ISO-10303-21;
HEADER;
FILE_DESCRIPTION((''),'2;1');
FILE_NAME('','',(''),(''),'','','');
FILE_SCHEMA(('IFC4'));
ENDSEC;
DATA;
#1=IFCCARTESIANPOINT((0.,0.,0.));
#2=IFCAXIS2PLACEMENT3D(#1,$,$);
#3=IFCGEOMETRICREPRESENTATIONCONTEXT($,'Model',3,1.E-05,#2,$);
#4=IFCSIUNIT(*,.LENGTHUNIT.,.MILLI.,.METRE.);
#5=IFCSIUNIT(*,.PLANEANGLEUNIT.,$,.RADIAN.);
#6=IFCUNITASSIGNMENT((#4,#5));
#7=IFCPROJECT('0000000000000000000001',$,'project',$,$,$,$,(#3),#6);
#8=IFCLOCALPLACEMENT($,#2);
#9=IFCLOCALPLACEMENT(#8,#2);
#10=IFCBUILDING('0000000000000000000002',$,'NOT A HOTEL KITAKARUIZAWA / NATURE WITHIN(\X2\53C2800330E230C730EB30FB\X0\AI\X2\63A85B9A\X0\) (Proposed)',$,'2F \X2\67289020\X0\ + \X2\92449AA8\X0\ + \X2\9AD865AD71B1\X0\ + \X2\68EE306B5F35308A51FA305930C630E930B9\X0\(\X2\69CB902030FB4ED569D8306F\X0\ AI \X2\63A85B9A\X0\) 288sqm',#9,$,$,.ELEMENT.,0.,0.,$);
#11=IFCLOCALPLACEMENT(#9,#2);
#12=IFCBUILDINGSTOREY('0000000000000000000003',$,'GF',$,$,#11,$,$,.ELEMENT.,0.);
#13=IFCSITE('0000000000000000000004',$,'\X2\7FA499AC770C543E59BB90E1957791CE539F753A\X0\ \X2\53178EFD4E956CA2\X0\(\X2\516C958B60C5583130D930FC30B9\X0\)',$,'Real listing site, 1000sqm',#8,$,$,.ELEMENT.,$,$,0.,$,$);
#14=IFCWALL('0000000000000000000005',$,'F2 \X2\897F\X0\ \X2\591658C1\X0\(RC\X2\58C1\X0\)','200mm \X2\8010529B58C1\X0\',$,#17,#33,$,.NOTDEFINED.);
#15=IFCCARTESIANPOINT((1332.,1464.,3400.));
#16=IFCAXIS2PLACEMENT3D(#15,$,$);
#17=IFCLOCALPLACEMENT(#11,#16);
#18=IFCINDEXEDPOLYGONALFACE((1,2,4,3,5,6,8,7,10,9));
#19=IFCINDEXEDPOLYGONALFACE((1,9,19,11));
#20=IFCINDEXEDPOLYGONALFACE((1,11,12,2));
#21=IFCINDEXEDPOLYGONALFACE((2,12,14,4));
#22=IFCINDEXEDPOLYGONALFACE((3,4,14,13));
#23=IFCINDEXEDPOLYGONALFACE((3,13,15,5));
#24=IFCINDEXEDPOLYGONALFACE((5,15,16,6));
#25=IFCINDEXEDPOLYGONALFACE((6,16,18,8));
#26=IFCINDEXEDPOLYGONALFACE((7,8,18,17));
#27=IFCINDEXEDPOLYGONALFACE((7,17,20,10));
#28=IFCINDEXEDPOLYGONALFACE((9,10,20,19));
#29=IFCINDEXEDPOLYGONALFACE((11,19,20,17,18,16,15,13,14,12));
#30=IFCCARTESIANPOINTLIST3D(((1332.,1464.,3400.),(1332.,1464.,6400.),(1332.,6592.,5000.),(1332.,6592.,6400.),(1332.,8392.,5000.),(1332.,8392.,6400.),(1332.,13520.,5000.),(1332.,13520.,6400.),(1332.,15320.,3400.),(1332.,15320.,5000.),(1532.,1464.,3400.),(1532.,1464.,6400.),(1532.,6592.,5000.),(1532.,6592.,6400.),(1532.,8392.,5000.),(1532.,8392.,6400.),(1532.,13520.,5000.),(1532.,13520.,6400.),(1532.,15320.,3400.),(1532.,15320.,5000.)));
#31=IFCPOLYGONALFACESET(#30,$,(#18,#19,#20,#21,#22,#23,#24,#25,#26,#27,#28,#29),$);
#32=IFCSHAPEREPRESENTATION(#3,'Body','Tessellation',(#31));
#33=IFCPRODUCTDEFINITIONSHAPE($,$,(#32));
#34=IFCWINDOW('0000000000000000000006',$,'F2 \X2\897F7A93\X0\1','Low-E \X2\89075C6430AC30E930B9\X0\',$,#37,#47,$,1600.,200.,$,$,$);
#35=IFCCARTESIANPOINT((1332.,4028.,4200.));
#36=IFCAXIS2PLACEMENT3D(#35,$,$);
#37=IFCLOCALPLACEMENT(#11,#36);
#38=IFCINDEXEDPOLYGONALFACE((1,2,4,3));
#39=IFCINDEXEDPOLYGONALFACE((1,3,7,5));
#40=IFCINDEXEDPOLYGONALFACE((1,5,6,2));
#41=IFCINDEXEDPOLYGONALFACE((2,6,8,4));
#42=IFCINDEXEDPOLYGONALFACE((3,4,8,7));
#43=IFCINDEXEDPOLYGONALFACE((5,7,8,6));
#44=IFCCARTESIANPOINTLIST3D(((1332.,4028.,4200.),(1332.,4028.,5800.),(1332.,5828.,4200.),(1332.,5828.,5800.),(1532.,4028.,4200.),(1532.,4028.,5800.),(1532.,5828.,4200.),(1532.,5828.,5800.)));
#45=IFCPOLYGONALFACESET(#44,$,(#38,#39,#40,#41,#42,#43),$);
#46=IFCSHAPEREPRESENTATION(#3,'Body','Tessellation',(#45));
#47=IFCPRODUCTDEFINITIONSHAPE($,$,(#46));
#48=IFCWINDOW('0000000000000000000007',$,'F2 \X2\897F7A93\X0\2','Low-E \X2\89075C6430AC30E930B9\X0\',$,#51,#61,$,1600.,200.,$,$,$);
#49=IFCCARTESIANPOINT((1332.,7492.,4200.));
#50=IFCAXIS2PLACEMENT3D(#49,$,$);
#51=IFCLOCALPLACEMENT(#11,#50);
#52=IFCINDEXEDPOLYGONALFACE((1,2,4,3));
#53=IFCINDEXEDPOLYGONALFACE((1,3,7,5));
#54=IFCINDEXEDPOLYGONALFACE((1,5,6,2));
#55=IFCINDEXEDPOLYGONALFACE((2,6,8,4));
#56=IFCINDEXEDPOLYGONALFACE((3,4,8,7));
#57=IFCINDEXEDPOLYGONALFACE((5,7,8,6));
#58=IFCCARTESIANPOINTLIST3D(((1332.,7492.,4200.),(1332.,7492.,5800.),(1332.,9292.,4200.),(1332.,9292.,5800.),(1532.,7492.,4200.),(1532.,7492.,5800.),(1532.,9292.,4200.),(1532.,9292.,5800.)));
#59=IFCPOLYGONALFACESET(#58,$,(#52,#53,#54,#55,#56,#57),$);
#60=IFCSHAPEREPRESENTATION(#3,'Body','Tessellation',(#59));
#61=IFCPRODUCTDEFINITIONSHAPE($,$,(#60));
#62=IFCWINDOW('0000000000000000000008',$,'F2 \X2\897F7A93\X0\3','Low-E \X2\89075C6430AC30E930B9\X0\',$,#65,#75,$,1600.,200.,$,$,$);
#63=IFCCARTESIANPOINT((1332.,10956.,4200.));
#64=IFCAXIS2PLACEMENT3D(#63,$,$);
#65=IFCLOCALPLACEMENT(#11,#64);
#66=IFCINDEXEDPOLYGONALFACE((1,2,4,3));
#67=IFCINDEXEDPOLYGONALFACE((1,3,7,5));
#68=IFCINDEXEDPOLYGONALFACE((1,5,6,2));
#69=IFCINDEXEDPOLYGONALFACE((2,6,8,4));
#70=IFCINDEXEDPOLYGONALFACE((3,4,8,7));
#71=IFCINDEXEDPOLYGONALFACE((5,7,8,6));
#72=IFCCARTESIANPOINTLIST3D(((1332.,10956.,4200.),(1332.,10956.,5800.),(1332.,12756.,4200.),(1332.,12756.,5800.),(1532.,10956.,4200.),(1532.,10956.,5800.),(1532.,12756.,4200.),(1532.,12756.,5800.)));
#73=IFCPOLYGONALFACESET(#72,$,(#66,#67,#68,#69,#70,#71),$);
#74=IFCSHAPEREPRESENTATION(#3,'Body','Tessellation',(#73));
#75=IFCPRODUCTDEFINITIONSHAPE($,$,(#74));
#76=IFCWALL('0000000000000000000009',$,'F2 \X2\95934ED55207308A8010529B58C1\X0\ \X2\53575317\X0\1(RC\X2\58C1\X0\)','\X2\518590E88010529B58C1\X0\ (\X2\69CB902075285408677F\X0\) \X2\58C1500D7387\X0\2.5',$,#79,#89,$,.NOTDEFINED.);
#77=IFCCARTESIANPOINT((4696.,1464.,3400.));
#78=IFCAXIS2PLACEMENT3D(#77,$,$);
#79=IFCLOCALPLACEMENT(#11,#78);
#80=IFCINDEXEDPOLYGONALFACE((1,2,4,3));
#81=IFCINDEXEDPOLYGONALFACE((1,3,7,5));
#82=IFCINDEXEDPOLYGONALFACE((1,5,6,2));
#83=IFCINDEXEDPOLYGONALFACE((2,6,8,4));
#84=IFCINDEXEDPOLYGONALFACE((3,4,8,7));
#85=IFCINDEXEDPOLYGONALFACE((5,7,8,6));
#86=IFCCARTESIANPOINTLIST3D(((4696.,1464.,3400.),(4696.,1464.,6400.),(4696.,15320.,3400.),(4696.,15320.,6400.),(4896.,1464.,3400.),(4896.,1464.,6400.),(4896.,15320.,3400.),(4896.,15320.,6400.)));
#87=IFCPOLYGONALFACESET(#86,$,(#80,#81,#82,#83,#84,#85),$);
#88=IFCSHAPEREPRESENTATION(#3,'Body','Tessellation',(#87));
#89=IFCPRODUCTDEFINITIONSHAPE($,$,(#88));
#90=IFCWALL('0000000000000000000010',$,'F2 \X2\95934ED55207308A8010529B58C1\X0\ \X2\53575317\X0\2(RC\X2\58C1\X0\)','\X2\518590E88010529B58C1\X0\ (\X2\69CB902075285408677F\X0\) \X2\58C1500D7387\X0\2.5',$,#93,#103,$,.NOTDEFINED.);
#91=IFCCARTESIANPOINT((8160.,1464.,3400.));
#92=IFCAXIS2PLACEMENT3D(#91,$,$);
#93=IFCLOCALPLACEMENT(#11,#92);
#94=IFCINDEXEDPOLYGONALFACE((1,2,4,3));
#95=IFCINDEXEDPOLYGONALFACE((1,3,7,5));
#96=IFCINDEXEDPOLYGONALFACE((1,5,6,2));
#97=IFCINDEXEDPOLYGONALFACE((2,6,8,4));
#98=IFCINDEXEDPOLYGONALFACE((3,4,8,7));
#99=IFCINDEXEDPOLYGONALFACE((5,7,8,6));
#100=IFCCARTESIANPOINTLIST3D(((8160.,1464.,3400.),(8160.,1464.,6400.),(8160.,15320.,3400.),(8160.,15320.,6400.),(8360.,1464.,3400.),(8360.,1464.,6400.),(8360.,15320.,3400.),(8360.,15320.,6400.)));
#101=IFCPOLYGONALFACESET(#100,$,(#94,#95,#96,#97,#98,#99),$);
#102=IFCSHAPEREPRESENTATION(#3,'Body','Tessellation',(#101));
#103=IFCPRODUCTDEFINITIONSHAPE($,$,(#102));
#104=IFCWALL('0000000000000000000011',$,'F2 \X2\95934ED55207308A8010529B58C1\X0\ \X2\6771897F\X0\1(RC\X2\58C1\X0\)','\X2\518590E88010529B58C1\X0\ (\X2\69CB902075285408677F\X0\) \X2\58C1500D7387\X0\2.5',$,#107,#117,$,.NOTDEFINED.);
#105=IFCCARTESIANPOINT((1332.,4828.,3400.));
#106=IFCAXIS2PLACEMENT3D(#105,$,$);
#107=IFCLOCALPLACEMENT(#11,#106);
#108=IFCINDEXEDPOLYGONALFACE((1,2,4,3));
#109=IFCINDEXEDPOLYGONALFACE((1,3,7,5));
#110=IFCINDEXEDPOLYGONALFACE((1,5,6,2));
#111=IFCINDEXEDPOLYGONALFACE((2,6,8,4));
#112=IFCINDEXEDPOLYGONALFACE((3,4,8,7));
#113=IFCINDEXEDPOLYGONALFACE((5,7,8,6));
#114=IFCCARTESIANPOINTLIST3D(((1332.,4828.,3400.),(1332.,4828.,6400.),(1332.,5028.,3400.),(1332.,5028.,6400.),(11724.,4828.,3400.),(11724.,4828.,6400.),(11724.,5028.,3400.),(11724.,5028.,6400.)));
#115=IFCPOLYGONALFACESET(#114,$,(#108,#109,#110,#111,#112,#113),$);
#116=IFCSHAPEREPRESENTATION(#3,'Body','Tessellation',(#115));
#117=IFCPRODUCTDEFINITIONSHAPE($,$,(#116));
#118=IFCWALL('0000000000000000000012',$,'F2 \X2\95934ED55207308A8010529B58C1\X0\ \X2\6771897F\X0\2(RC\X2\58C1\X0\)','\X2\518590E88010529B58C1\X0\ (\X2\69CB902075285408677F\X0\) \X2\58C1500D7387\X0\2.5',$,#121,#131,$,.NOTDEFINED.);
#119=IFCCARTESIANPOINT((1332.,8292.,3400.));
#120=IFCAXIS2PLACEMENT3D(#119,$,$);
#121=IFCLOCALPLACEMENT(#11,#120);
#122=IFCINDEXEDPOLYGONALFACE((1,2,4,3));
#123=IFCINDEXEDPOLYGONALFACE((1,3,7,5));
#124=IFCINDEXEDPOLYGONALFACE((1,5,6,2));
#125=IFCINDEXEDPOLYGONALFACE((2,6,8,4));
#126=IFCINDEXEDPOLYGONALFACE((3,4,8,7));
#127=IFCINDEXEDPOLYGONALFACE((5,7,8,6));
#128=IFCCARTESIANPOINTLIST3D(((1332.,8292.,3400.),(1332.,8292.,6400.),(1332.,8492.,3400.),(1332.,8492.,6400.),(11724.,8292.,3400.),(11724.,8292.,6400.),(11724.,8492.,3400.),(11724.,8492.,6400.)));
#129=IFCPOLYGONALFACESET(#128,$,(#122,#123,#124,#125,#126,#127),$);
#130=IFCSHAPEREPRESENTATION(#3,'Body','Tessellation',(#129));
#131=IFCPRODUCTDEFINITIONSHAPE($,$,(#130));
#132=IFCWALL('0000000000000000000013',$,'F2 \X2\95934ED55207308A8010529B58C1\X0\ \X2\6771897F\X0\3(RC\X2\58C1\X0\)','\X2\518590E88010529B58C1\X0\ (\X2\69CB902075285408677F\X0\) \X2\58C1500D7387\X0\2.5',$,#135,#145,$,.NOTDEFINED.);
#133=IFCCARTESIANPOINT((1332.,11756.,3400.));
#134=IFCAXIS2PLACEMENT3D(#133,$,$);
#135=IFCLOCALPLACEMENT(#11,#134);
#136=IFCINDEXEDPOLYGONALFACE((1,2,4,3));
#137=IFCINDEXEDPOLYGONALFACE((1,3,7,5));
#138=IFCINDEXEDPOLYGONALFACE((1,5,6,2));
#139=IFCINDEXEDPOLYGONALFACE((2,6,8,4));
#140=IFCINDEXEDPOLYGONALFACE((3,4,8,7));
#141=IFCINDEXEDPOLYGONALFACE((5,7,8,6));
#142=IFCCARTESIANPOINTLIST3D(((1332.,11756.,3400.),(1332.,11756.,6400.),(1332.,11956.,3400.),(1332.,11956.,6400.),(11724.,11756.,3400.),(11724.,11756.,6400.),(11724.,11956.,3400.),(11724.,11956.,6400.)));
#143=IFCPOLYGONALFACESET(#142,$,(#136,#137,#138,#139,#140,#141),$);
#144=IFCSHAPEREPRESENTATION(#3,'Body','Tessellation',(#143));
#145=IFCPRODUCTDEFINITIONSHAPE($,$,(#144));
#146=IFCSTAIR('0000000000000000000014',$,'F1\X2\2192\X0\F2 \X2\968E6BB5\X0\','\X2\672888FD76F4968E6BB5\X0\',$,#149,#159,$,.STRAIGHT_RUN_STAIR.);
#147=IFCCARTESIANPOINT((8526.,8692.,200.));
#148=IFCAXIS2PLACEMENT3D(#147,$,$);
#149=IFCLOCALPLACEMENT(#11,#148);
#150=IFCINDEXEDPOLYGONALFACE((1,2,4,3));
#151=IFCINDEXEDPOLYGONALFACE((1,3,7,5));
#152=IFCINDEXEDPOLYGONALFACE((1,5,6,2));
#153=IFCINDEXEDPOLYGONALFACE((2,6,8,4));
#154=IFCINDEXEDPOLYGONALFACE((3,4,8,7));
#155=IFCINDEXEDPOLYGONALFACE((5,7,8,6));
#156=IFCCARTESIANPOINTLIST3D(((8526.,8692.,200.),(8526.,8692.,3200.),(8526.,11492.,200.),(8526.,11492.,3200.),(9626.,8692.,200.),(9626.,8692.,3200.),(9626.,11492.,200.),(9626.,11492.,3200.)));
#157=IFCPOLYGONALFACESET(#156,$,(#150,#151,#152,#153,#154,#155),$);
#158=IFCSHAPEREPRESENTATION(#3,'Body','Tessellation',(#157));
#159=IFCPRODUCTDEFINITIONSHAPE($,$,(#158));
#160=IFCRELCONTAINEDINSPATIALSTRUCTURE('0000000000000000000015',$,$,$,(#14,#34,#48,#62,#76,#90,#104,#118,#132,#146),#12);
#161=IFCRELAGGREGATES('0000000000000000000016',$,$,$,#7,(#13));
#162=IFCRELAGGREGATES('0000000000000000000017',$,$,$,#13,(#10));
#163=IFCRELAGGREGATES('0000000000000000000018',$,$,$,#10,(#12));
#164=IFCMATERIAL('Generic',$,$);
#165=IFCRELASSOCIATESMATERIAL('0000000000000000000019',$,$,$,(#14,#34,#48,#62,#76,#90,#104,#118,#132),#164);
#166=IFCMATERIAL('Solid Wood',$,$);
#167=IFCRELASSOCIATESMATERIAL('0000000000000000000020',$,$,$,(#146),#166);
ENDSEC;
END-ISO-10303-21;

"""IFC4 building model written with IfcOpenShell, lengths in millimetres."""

from ifc_helpers import new_model, si_unit, frame, frame_2d, origin, place, context, project, spatial, rectangle, extrude, material, element, fill, save


model = new_model("IFC4")

# Units and contexts
model_context = context("Model", 3, precision=1e-05, world=origin())
ifc_project = project(units=[si_unit("LENGTHUNIT", "METRE", prefix="MILLI"), si_unit("PLANEANGLEUNIT", "RADIAN")], contexts=[model_context])

# Site, building, storey
site_placement = place(None, origin())
site = spatial("IfcSite", under=ifc_project, at=site_placement, Name="群馬県吾妻郡長野原町 北軽井沢(公開情報ベース)", ObjectType="Real listing site, 1000sqm", CompositionType="ELEMENT", RefElevation=0.0)
building_placement = place(site_placement, origin())
building = spatial("IfcBuilding", under=site, at=building_placement, Name="NOT A HOTEL KITAKARUIZAWA / NATURE WITHIN(参考モデル・AI推定) (Proposed)", ObjectType="2F 木造 + 鉄骨 + 高断熱 + 森に張り出すテラス(構造・仕様は AI 推定) 288sqm", CompositionType="ELEMENT", ElevationOfRefHeight=0.0, ElevationOfTerrain=0.0)
storey_placement = place(building_placement, origin())
storey = spatial("IfcBuildingStorey", under=building, at=storey_placement, Name="GF", CompositionType="ELEMENT", Elevation=0.0)

# Shared definitions
ifc_material_1 = material(Name="Generic")

# Wall, openings, windows
wall_1_placement = place(storey_placement, frame((1332.0, 1464.0, 3400.0)))
wall_1 = element("IfcWall", 1, at=wall_1_placement, inside=storey, material=ifc_material_1, Name="F2 西 外壁(RC壁)", Description="200mm 耐力壁", PredefinedType="NOTDEFINED", context=model_context, shape_type="SweptSolid", body=[
    extrude(rectangle(XDim=200.0, YDim=13856.0, at=frame_2d((100.0, 6928.0))), frame((1332.0, 1464.0, 3400.0)), (0.0, 0.0, 1.0), 3000.0),
])
opening_1_placement = place(storey_placement, frame((1332.0, 4028.0, 4200.0)))
opening_1 = element("IfcOpeningElement", 2, at=opening_1_placement, cuts=wall_1, PredefinedType="NOTDEFINED", context=model_context, shape_type="SweptSolid", body=[
    extrude(rectangle(XDim=200.0, YDim=1800.0, at=frame_2d((100.0, 900.0))), frame((1332.0, 4028.0, 4200.0)), (0.0, 0.0, 1.0), 1600.0),
])
opening_2_placement = place(storey_placement, frame((1332.0, 7492.0, 4200.0)))
opening_2 = element("IfcOpeningElement", 3, at=opening_2_placement, cuts=wall_1, PredefinedType="NOTDEFINED", context=model_context, shape_type="SweptSolid", body=[
    extrude(rectangle(XDim=200.0, YDim=1800.0, at=frame_2d((100.0, 900.0))), frame((1332.0, 7492.0, 4200.0)), (0.0, 0.0, 1.0), 1600.0),
])
opening_3_placement = place(storey_placement, frame((1332.0, 10956.0, 4200.0)))
opening_3 = element("IfcOpeningElement", 4, at=opening_3_placement, cuts=wall_1, PredefinedType="NOTDEFINED", context=model_context, shape_type="SweptSolid", body=[
    extrude(rectangle(XDim=200.0, YDim=1800.0, at=frame_2d((100.0, 900.0))), frame((1332.0, 10956.0, 4200.0)), (0.0, 0.0, 1.0), 1600.0),
])
window_1_placement = place(storey_placement, frame((1332.0, 4028.0, 4200.0)))
window_1 = element("IfcWindow", 5, at=window_1_placement, inside=storey, material=ifc_material_1, Name="F2 西窓1", Description="Low-E 複層ガラス", OverallHeight=1600.0, OverallWidth=200.0, context=model_context, shape_type="SweptSolid", body=[
    extrude(rectangle(XDim=200.0, YDim=1800.0, at=frame_2d((100.0, 900.0))), frame((1332.0, 4028.0, 4200.0)), (0.0, 0.0, 1.0), 1600.0),
])
fill(opening_1, window_1)
window_2_placement = place(storey_placement, frame((1332.0, 7492.0, 4200.0)))
window_2 = element("IfcWindow", 6, at=window_2_placement, inside=storey, material=ifc_material_1, Name="F2 西窓2", Description="Low-E 複層ガラス", OverallHeight=1600.0, OverallWidth=200.0, context=model_context, shape_type="SweptSolid", body=[
    extrude(rectangle(XDim=200.0, YDim=1800.0, at=frame_2d((100.0, 900.0))), frame((1332.0, 7492.0, 4200.0)), (0.0, 0.0, 1.0), 1600.0),
])
fill(opening_2, window_2)
window_3_placement = place(storey_placement, frame((1332.0, 10956.0, 4200.0)))
window_3 = element("IfcWindow", 7, at=window_3_placement, inside=storey, material=ifc_material_1, Name="F2 西窓3", Description="Low-E 複層ガラス", OverallHeight=1600.0, OverallWidth=200.0, context=model_context, shape_type="SweptSolid", body=[
    extrude(rectangle(XDim=200.0, YDim=1800.0, at=frame_2d((100.0, 900.0))), frame((1332.0, 10956.0, 4200.0)), (0.0, 0.0, 1.0), 1600.0),
])
fill(opening_3, window_3)

# Walls
wall_2_placement = place(storey_placement, frame((4696.0, 1464.0, 3400.0)))
element("IfcWall", 8, at=wall_2_placement, inside=storey, material=ifc_material_1, Name="F2 間仕切り耐力壁 南北1(RC壁)", Description="内部耐力壁 (構造用合板) 壁倍率2.5", PredefinedType="NOTDEFINED", context=model_context, shape_type="SweptSolid", body=[
    extrude(rectangle(XDim=200.0, YDim=13856.0, at=frame_2d((100.0, 6928.0))), frame((4696.0, 1464.0, 3400.0)), (0.0, 0.0, 1.0), 3000.0),
])
wall_3_placement = place(storey_placement, frame((8160.0, 1464.0, 3400.0)))
element("IfcWall", 9, at=wall_3_placement, inside=storey, material=ifc_material_1, Name="F2 間仕切り耐力壁 南北2(RC壁)", Description="内部耐力壁 (構造用合板) 壁倍率2.5", PredefinedType="NOTDEFINED", context=model_context, shape_type="SweptSolid", body=[
    extrude(rectangle(XDim=200.0, YDim=13856.0, at=frame_2d((100.0, 6928.0))), frame((8160.0, 1464.0, 3400.0)), (0.0, 0.0, 1.0), 3000.0),
])
wall_4_placement = place(storey_placement, frame((1332.0, 4828.0, 3400.0)))
element("IfcWall", 10, at=wall_4_placement, inside=storey, material=ifc_material_1, Name="F2 間仕切り耐力壁 東西1(RC壁)", Description="内部耐力壁 (構造用合板) 壁倍率2.5", PredefinedType="NOTDEFINED", context=model_context, shape_type="SweptSolid", body=[
    extrude(rectangle(XDim=10392.0, YDim=200.0, at=frame_2d((5196.0, 100.0))), frame((1332.0, 4828.0, 3400.0)), (0.0, 0.0, 1.0), 3000.0),
])
wall_5_placement = place(storey_placement, frame((1332.0, 8292.0, 3400.0)))
element("IfcWall", 11, at=wall_5_placement, inside=storey, material=ifc_material_1, Name="F2 間仕切り耐力壁 東西2(RC壁)", Description="内部耐力壁 (構造用合板) 壁倍率2.5", PredefinedType="NOTDEFINED", context=model_context, shape_type="SweptSolid", body=[
    extrude(rectangle(XDim=10392.0, YDim=200.0, at=frame_2d((5196.0, 100.0))), frame((1332.0, 8292.0, 3400.0)), (0.0, 0.0, 1.0), 3000.0),
])
wall_6_placement = place(storey_placement, frame((1332.0, 11756.0, 3400.0)))
element("IfcWall", 12, at=wall_6_placement, inside=storey, material=ifc_material_1, Name="F2 間仕切り耐力壁 東西3(RC壁)", Description="内部耐力壁 (構造用合板) 壁倍率2.5", PredefinedType="NOTDEFINED", context=model_context, shape_type="SweptSolid", body=[
    extrude(rectangle(XDim=10392.0, YDim=200.0, at=frame_2d((5196.0, 100.0))), frame((1332.0, 11756.0, 3400.0)), (0.0, 0.0, 1.0), 3000.0),
])

# Stair
ifc_material_2 = material(Name="Solid Wood")
stair_placement = place(storey_placement, frame((8526.0, 8692.0, 200.0)))
element("IfcStair", 13, at=stair_placement, inside=storey, material=ifc_material_2, Name="F1→F2 階段", Description="木製直階段", PredefinedType="STRAIGHT_RUN_STAIR", context=model_context, shape_type="SweptSolid", body=[
    extrude(rectangle(XDim=1100.0, YDim=2800.0, at=frame_2d((550.0, 1400.0))), frame((8526.0, 8692.0, 200.0)), (0.0, 0.0, 1.0), 3000.0),
])

save(model, "model.ifc")
